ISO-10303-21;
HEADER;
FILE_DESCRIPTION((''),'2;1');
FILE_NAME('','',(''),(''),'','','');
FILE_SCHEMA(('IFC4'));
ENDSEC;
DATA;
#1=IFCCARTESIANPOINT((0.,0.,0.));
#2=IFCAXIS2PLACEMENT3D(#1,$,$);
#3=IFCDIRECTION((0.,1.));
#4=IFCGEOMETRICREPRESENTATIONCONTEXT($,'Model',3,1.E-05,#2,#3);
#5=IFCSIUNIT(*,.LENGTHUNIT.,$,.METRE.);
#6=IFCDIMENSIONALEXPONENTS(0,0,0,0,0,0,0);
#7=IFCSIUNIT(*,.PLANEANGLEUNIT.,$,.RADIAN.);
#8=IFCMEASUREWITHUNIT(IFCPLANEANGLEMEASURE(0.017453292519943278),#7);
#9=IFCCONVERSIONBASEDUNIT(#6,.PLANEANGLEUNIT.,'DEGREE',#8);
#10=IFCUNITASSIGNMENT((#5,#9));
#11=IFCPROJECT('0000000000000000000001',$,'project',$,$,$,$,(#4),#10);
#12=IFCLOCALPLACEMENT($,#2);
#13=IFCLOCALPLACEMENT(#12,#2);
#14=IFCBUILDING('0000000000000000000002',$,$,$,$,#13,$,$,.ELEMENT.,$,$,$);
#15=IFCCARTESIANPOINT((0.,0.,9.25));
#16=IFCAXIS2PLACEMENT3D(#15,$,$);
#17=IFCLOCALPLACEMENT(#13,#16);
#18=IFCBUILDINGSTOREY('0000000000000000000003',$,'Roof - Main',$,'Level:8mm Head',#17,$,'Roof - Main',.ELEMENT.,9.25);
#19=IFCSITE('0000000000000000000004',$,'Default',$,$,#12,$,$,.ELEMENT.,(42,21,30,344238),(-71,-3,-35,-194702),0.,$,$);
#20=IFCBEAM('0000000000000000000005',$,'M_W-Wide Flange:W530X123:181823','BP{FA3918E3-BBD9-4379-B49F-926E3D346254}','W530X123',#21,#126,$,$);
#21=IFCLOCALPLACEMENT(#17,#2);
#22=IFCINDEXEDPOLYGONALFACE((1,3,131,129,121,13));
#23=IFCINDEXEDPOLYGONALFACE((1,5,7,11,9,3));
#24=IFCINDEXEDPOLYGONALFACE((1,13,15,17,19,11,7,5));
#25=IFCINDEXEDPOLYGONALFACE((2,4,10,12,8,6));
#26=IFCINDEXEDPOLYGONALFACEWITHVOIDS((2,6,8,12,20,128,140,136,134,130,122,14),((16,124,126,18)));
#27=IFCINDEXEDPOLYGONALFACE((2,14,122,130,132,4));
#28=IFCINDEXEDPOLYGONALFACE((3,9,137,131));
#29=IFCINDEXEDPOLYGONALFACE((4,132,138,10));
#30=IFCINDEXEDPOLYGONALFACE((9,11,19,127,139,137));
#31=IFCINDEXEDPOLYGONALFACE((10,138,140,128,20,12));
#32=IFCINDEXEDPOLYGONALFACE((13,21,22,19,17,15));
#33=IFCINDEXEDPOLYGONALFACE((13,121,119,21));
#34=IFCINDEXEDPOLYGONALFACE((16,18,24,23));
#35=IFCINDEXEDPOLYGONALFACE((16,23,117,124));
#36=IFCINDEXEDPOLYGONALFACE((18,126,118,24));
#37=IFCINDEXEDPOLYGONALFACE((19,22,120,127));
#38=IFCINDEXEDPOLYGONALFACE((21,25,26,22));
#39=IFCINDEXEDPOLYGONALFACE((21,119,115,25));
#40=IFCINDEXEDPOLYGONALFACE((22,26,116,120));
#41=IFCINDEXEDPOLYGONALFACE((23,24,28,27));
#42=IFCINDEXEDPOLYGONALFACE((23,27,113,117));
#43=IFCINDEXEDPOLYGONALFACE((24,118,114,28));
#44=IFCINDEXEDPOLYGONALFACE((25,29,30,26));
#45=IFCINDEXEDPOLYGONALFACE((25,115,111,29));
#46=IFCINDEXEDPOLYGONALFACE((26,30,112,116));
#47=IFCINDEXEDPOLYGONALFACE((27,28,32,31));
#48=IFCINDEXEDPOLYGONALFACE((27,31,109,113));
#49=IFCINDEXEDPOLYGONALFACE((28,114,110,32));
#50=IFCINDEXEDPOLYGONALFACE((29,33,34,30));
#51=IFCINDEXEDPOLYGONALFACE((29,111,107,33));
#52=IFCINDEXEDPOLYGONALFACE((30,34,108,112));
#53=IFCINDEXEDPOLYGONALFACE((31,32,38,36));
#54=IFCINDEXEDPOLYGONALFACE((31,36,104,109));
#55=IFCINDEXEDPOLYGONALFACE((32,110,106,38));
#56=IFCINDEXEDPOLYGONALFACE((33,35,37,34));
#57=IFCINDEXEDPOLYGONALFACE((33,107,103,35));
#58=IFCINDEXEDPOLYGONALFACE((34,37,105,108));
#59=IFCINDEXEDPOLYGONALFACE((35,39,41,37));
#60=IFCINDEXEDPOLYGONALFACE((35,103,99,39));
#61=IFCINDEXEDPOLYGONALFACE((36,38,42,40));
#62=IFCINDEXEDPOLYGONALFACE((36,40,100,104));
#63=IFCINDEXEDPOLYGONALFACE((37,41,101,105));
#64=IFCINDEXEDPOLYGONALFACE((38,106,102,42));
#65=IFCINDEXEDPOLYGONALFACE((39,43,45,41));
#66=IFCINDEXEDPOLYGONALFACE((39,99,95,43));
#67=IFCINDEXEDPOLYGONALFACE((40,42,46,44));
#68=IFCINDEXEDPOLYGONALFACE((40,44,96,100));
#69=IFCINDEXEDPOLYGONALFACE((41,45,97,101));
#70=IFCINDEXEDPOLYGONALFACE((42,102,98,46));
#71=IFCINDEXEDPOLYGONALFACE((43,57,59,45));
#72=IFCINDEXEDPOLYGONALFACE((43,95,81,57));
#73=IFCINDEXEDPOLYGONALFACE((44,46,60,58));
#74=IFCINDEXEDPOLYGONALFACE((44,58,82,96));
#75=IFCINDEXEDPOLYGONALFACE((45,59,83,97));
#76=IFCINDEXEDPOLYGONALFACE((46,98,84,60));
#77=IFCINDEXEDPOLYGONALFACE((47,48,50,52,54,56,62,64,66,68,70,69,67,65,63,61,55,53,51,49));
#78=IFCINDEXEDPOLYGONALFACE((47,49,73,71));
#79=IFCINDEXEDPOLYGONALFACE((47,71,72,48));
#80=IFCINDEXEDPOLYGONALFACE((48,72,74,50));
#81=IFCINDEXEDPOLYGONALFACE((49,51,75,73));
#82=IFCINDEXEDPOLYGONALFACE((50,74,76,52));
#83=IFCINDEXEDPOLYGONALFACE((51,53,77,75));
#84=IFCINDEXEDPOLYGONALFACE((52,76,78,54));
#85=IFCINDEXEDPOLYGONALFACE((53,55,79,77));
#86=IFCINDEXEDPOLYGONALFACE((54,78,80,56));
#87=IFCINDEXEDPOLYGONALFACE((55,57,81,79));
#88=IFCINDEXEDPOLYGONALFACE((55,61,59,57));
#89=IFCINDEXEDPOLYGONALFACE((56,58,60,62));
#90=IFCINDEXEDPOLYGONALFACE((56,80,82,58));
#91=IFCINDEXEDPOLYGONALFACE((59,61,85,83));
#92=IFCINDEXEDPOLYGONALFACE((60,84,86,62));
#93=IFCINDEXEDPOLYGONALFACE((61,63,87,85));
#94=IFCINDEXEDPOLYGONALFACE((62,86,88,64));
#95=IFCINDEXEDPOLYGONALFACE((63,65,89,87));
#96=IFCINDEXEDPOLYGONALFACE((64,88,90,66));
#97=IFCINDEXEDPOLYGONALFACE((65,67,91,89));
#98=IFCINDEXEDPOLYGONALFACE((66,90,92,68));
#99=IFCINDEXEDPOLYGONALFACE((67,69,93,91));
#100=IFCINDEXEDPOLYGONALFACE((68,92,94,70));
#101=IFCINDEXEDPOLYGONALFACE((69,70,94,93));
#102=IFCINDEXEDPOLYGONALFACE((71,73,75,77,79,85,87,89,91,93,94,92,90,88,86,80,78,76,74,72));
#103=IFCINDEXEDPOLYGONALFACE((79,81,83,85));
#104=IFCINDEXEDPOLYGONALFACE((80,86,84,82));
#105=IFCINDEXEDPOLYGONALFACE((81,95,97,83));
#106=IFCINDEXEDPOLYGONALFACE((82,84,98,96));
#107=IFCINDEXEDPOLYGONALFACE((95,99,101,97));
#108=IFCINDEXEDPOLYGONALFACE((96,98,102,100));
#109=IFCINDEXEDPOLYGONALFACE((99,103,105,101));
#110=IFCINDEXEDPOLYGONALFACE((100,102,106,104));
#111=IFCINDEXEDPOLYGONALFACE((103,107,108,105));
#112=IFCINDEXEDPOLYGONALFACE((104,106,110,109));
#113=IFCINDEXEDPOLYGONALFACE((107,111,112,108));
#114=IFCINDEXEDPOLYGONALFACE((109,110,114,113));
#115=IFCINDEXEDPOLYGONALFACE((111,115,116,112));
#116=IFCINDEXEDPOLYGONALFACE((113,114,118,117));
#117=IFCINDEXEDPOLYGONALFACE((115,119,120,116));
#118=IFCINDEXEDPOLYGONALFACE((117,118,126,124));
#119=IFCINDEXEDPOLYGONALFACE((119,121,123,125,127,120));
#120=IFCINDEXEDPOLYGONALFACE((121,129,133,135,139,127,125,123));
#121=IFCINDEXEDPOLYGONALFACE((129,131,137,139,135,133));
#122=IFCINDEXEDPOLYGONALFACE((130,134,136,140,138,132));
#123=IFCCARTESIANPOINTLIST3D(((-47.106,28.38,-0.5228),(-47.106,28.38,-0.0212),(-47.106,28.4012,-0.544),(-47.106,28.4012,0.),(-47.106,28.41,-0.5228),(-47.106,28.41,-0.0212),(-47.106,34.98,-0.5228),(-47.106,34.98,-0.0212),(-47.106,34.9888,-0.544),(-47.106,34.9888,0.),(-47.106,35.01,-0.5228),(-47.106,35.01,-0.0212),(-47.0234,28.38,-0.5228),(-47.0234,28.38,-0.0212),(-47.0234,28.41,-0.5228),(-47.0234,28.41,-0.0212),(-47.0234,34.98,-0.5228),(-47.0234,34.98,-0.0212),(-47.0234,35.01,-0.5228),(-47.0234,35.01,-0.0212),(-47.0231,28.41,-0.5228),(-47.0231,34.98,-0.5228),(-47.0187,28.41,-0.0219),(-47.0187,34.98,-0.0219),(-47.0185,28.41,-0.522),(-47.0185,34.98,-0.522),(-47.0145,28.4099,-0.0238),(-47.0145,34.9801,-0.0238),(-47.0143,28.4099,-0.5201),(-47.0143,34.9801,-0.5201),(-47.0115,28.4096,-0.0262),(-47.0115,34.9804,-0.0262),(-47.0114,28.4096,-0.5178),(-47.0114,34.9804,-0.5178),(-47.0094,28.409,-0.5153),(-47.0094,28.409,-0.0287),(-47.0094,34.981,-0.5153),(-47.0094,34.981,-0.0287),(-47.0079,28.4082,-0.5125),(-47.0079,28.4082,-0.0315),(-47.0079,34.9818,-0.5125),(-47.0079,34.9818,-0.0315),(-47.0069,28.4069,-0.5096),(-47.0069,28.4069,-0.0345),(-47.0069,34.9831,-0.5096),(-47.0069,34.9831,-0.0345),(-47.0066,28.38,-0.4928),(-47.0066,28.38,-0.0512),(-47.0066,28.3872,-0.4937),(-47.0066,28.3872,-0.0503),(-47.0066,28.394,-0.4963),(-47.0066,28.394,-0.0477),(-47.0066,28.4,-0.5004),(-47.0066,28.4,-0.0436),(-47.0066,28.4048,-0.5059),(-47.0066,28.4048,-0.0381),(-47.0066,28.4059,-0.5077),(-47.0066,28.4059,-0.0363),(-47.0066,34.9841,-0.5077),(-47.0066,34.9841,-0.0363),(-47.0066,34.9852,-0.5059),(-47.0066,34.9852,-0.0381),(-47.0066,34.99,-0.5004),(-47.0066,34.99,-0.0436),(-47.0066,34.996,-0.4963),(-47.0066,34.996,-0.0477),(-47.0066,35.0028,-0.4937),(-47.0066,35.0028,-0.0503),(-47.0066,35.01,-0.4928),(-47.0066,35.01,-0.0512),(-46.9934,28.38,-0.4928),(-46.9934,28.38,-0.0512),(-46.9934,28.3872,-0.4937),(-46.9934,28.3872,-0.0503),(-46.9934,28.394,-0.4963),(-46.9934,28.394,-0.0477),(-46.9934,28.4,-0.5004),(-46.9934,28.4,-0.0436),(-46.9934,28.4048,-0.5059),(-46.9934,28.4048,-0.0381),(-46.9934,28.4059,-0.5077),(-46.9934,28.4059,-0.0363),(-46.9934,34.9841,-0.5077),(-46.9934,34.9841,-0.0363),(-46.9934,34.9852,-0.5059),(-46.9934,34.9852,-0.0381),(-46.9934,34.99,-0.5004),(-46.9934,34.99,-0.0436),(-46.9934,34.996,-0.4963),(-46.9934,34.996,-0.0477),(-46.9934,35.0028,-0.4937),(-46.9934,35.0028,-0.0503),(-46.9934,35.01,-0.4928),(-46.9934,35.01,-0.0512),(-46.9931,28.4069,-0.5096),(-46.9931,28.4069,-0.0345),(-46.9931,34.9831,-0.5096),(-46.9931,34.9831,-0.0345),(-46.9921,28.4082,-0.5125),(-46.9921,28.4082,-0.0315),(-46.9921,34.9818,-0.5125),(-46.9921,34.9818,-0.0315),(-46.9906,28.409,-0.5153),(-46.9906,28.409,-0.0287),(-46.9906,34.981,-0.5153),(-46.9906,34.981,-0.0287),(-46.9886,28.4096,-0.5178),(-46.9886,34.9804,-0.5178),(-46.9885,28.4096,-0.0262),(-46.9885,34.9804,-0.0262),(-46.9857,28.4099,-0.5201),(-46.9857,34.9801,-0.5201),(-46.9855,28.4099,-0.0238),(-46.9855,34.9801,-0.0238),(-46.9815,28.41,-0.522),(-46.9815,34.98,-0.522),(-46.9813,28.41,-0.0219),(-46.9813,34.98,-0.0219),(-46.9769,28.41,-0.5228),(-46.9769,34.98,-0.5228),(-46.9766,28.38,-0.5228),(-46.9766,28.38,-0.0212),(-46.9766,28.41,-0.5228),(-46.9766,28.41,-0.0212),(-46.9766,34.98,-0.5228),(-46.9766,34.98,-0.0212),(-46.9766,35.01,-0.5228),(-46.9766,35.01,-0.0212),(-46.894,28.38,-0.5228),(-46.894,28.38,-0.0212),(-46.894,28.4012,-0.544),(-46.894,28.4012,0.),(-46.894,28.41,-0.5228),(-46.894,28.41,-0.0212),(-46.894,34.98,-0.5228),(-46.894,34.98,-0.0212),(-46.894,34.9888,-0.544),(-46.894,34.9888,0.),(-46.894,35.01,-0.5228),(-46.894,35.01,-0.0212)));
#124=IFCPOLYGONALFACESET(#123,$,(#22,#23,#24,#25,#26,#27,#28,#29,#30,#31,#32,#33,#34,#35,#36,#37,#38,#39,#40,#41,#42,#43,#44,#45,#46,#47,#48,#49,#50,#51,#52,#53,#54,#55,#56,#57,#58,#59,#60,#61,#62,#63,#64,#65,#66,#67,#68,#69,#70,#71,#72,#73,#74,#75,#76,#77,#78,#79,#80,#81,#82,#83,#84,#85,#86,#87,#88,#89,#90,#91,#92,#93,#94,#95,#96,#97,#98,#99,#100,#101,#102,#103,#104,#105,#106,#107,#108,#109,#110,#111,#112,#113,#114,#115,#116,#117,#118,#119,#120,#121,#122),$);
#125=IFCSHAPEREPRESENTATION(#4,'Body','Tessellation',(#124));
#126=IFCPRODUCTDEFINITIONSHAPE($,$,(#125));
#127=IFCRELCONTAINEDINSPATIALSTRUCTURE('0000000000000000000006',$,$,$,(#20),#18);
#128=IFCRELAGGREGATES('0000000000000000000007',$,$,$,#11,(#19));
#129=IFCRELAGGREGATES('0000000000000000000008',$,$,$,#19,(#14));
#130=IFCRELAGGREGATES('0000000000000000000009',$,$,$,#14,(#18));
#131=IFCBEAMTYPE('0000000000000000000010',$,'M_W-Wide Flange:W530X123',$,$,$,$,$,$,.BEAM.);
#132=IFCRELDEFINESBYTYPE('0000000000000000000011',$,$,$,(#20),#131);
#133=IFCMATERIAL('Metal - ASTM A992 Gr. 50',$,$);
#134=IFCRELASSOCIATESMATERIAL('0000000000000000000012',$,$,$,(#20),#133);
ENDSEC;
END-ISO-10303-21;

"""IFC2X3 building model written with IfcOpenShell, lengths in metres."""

from ifc_helpers import new_model, entity, si_unit, converted_unit, point, direction, frame, frame_2d, origin, origin_2d, place, context, project, spatial, polyline, circle_curve, line_curve, trimmed, segment, composite_curve, i_section, outline, extrude, material, type_object, element, save


model = new_model("IFC2X3")

# Units and contexts
model_context = context("Model", 3, precision=1e-05, world=origin(), true_north=direction((0.0, 1.0)))
ifc_project = project(units=[si_unit("LENGTHUNIT", "METRE"), converted_unit("PLANEANGLEUNIT", "DEGREE", entity("IfcPlaneAngleMeasure", 0.017453292519943278), si_unit("PLANEANGLEUNIT", "RADIAN"), dimensions=[0, 0, 0, 0, 0, 0, 0])], contexts=[model_context])

# Site, building, storey
site_placement = place(None, origin())
site = spatial("IfcSite", under=ifc_project, at=site_placement, Name="Default", CompositionType="ELEMENT", RefLatitude=(42, 21, 30, 344238), RefLongitude=(-71, -3, -35, -194702), RefElevation=0.0)
building_placement = place(site_placement, origin())
building = spatial("IfcBuilding", under=site, at=building_placement, CompositionType="ELEMENT")
storey_placement = place(building_placement, frame((0.0, 0.0, 9.25)))
storey = spatial("IfcBuildingStorey", under=building, at=storey_placement, Name="Roof - Main", ObjectType="Level:8mm Head", LongName="Roof - Main", CompositionType="ELEMENT", Elevation=9.25)

# Beam, openings
ifc_material_1 = material(Name="Metal - ASTM A992 Gr. 50")
beam_type_1 = type_object("IfcBeamType", Name="M_W-Wide Flange:W530X123", PredefinedType="BEAM")
beam_1_placement = place(storey_placement, frame((-47.0, 35.01, -0.272), z_axis=(0.0, 1.0, 0.0), x_axis=(-1.0, 0.0, 0.0)))
beam_1 = element("IfcBeam", 1, at=beam_1_placement, inside=storey, type_object=beam_type_1, material=ifc_material_1, Name="M_W-Wide Flange:W530X123:181823", Description="BP{FA3918E3-BBD9-4379-B49F-926E3D346254}", ObjectType="W530X123", context=model_context, shape_type="SweptSolid", body=[
    extrude(i_section(OverallWidth=0.212, OverallDepth=0.544, WebThickness=0.0131, FlangeThickness=0.0212, FilletRadius=0.0169, at=origin_2d()), origin(), (0.0, 0.0, -1.0), 6.63),
])
opening_1_placement = place(beam_1_placement, frame((-0.2061, 0.272, -6.63), z_axis=(1.0, 0.0, 0.0), x_axis=(0.0, 0.0, -1.0)))
element("IfcOpeningElement", 2, at=opening_1_placement, cuts=beam_1, ObjectType="Opening", context=model_context, shape_type="SweptSolid", body=[
    extrude(outline(polyline([(0.0, -0.0212), (0.0, 0.0), (-0.0212, 0.0), (0.0, -0.0212)])), origin(), (0.0, 0.0, 1.0), 0.4122),
])
opening_2_placement = place(beam_1_placement, frame((0.2061, 0.272, -6.63), z_axis=(-1.0, 0.0, 0.0), x_axis=(0.0, 0.0, 1.0)))
element("IfcOpeningElement", 3, at=opening_2_placement, cuts=beam_1, ObjectType="Opening", context=model_context, shape_type="SweptSolid", body=[
    extrude(outline(polyline([(0.0, -0.5228), (0.0, -0.544), (0.0212, -0.544), (0.0, -0.5228)])), origin(), (0.0, 0.0, 1.0), 0.4122),
])
opening_3_placement = place(beam_1_placement, frame((-0.2061, 0.272, -6.63), z_axis=(1.0, 0.0, 0.0), x_axis=(0.0, 0.0, -1.0)))
element("IfcOpeningElement", 4, at=opening_3_placement, cuts=beam_1, ObjectType="Opening", context=model_context, shape_type="SweptSolid", body=[
    extrude(outline(composite_curve([segment(trimmed(circle_curve(frame_2d((0.0, -0.0212), x_axis=(1.0, 0.0)), 0.03), [point((-0.03, -0.0212))], [point((0.03, -0.0212))], True, "CARTESIAN"), True, "CONTINUOUS"), segment(trimmed(line_curve((0.03, -0.0212), (-1.0, 0.0), 0.06), [point((0.03, -0.0212))], [point((-0.03, -0.0212))], True, "CARTESIAN"), True, "CONTINUOUS")], self_intersect="UNKNOWN")), origin(), (0.0, 0.0, 1.0), 0.4122),
])
opening_4_placement = place(beam_1_placement, frame((0.2061, 0.272, -6.63), z_axis=(-1.0, 0.0, 0.0), x_axis=(0.0, 0.0, 1.0)))
element("IfcOpeningElement", 5, at=opening_4_placement, cuts=beam_1, ObjectType="Opening", context=model_context, shape_type="SweptSolid", body=[
    extrude(outline(composite_curve([segment(trimmed(circle_curve(frame_2d((0.0, -0.5228), x_axis=(1.0, 0.0)), 0.03), [point((0.03, -0.5228))], [point((-0.03, -0.5228))], True, "CARTESIAN"), True, "CONTINUOUS"), segment(trimmed(line_curve((-0.03, -0.5228), (1.0, 0.0), 0.06), [point((-0.03, -0.5228))], [point((0.03, -0.5228))], True, "CARTESIAN"), True, "CONTINUOUS")], self_intersect="UNKNOWN")), origin(), (0.0, 0.0, 1.0), 0.4122),
])
opening_5_placement = place(beam_1_placement, frame((0.2061, 0.272, 0.0), z_axis=(-1.0, 0.0, 0.0), x_axis=(0.0, 0.0, 1.0)))
element("IfcOpeningElement", 6, at=opening_5_placement, cuts=beam_1, ObjectType="Opening", context=model_context, shape_type="SweptSolid", body=[
    extrude(outline(polyline([(0.0, -0.0212), (0.0, 0.0), (-0.0212, 0.0), (0.0, -0.0212)])), origin(), (0.0, 0.0, 1.0), 0.4122),
])
opening_6_placement = place(beam_1_placement, frame((-0.2061, 0.272, 0.0), z_axis=(1.0, 0.0, 0.0), x_axis=(0.0, 0.0, -1.0)))
element("IfcOpeningElement", 7, at=opening_6_placement, cuts=beam_1, ObjectType="Opening", context=model_context, shape_type="SweptSolid", body=[
    extrude(outline(polyline([(0.0, -0.5228), (0.0, -0.544), (0.0212, -0.544), (0.0, -0.5228)])), origin(), (0.0, 0.0, 1.0), 0.4122),
])
opening_7_placement = place(beam_1_placement, frame((0.2061, 0.272, 0.0), z_axis=(-1.0, 0.0, 0.0), x_axis=(0.0, 0.0, 1.0)))
element("IfcOpeningElement", 8, at=opening_7_placement, cuts=beam_1, ObjectType="Opening", context=model_context, shape_type="SweptSolid", body=[
    extrude(outline(composite_curve([segment(trimmed(circle_curve(frame_2d((0.0, -0.0212), x_axis=(1.0, 0.0)), 0.03), [point((-0.03, -0.0212))], [point((0.03, -0.0212))], True, "CARTESIAN"), True, "CONTINUOUS"), segment(trimmed(line_curve((0.03, -0.0212), (-1.0, 0.0), 0.06), [point((0.03, -0.0212))], [point((-0.03, -0.0212))], True, "CARTESIAN"), True, "CONTINUOUS")], self_intersect="UNKNOWN")), origin(), (0.0, 0.0, 1.0), 0.4122),
])
opening_8_placement = place(beam_1_placement, frame((-0.2061, 0.272, 0.0), z_axis=(1.0, 0.0, 0.0), x_axis=(0.0, 0.0, -1.0)))
element("IfcOpeningElement", 9, at=opening_8_placement, cuts=beam_1, ObjectType="Opening", context=model_context, shape_type="SweptSolid", body=[
    extrude(outline(composite_curve([segment(trimmed(circle_curve(frame_2d((0.0, -0.5228), x_axis=(1.0, 0.0)), 0.03), [point((0.03, -0.5228))], [point((-0.03, -0.5228))], True, "CARTESIAN"), True, "CONTINUOUS"), segment(trimmed(line_curve((-0.03, -0.5228), (1.0, 0.0), 0.06), [point((-0.03, -0.5228))], [point((0.03, -0.5228))], True, "CARTESIAN"), True, "CONTINUOUS")], self_intersect="UNKNOWN")), origin(), (0.0, 0.0, 1.0), 0.4122),
])

save(model, "model.ifc")
